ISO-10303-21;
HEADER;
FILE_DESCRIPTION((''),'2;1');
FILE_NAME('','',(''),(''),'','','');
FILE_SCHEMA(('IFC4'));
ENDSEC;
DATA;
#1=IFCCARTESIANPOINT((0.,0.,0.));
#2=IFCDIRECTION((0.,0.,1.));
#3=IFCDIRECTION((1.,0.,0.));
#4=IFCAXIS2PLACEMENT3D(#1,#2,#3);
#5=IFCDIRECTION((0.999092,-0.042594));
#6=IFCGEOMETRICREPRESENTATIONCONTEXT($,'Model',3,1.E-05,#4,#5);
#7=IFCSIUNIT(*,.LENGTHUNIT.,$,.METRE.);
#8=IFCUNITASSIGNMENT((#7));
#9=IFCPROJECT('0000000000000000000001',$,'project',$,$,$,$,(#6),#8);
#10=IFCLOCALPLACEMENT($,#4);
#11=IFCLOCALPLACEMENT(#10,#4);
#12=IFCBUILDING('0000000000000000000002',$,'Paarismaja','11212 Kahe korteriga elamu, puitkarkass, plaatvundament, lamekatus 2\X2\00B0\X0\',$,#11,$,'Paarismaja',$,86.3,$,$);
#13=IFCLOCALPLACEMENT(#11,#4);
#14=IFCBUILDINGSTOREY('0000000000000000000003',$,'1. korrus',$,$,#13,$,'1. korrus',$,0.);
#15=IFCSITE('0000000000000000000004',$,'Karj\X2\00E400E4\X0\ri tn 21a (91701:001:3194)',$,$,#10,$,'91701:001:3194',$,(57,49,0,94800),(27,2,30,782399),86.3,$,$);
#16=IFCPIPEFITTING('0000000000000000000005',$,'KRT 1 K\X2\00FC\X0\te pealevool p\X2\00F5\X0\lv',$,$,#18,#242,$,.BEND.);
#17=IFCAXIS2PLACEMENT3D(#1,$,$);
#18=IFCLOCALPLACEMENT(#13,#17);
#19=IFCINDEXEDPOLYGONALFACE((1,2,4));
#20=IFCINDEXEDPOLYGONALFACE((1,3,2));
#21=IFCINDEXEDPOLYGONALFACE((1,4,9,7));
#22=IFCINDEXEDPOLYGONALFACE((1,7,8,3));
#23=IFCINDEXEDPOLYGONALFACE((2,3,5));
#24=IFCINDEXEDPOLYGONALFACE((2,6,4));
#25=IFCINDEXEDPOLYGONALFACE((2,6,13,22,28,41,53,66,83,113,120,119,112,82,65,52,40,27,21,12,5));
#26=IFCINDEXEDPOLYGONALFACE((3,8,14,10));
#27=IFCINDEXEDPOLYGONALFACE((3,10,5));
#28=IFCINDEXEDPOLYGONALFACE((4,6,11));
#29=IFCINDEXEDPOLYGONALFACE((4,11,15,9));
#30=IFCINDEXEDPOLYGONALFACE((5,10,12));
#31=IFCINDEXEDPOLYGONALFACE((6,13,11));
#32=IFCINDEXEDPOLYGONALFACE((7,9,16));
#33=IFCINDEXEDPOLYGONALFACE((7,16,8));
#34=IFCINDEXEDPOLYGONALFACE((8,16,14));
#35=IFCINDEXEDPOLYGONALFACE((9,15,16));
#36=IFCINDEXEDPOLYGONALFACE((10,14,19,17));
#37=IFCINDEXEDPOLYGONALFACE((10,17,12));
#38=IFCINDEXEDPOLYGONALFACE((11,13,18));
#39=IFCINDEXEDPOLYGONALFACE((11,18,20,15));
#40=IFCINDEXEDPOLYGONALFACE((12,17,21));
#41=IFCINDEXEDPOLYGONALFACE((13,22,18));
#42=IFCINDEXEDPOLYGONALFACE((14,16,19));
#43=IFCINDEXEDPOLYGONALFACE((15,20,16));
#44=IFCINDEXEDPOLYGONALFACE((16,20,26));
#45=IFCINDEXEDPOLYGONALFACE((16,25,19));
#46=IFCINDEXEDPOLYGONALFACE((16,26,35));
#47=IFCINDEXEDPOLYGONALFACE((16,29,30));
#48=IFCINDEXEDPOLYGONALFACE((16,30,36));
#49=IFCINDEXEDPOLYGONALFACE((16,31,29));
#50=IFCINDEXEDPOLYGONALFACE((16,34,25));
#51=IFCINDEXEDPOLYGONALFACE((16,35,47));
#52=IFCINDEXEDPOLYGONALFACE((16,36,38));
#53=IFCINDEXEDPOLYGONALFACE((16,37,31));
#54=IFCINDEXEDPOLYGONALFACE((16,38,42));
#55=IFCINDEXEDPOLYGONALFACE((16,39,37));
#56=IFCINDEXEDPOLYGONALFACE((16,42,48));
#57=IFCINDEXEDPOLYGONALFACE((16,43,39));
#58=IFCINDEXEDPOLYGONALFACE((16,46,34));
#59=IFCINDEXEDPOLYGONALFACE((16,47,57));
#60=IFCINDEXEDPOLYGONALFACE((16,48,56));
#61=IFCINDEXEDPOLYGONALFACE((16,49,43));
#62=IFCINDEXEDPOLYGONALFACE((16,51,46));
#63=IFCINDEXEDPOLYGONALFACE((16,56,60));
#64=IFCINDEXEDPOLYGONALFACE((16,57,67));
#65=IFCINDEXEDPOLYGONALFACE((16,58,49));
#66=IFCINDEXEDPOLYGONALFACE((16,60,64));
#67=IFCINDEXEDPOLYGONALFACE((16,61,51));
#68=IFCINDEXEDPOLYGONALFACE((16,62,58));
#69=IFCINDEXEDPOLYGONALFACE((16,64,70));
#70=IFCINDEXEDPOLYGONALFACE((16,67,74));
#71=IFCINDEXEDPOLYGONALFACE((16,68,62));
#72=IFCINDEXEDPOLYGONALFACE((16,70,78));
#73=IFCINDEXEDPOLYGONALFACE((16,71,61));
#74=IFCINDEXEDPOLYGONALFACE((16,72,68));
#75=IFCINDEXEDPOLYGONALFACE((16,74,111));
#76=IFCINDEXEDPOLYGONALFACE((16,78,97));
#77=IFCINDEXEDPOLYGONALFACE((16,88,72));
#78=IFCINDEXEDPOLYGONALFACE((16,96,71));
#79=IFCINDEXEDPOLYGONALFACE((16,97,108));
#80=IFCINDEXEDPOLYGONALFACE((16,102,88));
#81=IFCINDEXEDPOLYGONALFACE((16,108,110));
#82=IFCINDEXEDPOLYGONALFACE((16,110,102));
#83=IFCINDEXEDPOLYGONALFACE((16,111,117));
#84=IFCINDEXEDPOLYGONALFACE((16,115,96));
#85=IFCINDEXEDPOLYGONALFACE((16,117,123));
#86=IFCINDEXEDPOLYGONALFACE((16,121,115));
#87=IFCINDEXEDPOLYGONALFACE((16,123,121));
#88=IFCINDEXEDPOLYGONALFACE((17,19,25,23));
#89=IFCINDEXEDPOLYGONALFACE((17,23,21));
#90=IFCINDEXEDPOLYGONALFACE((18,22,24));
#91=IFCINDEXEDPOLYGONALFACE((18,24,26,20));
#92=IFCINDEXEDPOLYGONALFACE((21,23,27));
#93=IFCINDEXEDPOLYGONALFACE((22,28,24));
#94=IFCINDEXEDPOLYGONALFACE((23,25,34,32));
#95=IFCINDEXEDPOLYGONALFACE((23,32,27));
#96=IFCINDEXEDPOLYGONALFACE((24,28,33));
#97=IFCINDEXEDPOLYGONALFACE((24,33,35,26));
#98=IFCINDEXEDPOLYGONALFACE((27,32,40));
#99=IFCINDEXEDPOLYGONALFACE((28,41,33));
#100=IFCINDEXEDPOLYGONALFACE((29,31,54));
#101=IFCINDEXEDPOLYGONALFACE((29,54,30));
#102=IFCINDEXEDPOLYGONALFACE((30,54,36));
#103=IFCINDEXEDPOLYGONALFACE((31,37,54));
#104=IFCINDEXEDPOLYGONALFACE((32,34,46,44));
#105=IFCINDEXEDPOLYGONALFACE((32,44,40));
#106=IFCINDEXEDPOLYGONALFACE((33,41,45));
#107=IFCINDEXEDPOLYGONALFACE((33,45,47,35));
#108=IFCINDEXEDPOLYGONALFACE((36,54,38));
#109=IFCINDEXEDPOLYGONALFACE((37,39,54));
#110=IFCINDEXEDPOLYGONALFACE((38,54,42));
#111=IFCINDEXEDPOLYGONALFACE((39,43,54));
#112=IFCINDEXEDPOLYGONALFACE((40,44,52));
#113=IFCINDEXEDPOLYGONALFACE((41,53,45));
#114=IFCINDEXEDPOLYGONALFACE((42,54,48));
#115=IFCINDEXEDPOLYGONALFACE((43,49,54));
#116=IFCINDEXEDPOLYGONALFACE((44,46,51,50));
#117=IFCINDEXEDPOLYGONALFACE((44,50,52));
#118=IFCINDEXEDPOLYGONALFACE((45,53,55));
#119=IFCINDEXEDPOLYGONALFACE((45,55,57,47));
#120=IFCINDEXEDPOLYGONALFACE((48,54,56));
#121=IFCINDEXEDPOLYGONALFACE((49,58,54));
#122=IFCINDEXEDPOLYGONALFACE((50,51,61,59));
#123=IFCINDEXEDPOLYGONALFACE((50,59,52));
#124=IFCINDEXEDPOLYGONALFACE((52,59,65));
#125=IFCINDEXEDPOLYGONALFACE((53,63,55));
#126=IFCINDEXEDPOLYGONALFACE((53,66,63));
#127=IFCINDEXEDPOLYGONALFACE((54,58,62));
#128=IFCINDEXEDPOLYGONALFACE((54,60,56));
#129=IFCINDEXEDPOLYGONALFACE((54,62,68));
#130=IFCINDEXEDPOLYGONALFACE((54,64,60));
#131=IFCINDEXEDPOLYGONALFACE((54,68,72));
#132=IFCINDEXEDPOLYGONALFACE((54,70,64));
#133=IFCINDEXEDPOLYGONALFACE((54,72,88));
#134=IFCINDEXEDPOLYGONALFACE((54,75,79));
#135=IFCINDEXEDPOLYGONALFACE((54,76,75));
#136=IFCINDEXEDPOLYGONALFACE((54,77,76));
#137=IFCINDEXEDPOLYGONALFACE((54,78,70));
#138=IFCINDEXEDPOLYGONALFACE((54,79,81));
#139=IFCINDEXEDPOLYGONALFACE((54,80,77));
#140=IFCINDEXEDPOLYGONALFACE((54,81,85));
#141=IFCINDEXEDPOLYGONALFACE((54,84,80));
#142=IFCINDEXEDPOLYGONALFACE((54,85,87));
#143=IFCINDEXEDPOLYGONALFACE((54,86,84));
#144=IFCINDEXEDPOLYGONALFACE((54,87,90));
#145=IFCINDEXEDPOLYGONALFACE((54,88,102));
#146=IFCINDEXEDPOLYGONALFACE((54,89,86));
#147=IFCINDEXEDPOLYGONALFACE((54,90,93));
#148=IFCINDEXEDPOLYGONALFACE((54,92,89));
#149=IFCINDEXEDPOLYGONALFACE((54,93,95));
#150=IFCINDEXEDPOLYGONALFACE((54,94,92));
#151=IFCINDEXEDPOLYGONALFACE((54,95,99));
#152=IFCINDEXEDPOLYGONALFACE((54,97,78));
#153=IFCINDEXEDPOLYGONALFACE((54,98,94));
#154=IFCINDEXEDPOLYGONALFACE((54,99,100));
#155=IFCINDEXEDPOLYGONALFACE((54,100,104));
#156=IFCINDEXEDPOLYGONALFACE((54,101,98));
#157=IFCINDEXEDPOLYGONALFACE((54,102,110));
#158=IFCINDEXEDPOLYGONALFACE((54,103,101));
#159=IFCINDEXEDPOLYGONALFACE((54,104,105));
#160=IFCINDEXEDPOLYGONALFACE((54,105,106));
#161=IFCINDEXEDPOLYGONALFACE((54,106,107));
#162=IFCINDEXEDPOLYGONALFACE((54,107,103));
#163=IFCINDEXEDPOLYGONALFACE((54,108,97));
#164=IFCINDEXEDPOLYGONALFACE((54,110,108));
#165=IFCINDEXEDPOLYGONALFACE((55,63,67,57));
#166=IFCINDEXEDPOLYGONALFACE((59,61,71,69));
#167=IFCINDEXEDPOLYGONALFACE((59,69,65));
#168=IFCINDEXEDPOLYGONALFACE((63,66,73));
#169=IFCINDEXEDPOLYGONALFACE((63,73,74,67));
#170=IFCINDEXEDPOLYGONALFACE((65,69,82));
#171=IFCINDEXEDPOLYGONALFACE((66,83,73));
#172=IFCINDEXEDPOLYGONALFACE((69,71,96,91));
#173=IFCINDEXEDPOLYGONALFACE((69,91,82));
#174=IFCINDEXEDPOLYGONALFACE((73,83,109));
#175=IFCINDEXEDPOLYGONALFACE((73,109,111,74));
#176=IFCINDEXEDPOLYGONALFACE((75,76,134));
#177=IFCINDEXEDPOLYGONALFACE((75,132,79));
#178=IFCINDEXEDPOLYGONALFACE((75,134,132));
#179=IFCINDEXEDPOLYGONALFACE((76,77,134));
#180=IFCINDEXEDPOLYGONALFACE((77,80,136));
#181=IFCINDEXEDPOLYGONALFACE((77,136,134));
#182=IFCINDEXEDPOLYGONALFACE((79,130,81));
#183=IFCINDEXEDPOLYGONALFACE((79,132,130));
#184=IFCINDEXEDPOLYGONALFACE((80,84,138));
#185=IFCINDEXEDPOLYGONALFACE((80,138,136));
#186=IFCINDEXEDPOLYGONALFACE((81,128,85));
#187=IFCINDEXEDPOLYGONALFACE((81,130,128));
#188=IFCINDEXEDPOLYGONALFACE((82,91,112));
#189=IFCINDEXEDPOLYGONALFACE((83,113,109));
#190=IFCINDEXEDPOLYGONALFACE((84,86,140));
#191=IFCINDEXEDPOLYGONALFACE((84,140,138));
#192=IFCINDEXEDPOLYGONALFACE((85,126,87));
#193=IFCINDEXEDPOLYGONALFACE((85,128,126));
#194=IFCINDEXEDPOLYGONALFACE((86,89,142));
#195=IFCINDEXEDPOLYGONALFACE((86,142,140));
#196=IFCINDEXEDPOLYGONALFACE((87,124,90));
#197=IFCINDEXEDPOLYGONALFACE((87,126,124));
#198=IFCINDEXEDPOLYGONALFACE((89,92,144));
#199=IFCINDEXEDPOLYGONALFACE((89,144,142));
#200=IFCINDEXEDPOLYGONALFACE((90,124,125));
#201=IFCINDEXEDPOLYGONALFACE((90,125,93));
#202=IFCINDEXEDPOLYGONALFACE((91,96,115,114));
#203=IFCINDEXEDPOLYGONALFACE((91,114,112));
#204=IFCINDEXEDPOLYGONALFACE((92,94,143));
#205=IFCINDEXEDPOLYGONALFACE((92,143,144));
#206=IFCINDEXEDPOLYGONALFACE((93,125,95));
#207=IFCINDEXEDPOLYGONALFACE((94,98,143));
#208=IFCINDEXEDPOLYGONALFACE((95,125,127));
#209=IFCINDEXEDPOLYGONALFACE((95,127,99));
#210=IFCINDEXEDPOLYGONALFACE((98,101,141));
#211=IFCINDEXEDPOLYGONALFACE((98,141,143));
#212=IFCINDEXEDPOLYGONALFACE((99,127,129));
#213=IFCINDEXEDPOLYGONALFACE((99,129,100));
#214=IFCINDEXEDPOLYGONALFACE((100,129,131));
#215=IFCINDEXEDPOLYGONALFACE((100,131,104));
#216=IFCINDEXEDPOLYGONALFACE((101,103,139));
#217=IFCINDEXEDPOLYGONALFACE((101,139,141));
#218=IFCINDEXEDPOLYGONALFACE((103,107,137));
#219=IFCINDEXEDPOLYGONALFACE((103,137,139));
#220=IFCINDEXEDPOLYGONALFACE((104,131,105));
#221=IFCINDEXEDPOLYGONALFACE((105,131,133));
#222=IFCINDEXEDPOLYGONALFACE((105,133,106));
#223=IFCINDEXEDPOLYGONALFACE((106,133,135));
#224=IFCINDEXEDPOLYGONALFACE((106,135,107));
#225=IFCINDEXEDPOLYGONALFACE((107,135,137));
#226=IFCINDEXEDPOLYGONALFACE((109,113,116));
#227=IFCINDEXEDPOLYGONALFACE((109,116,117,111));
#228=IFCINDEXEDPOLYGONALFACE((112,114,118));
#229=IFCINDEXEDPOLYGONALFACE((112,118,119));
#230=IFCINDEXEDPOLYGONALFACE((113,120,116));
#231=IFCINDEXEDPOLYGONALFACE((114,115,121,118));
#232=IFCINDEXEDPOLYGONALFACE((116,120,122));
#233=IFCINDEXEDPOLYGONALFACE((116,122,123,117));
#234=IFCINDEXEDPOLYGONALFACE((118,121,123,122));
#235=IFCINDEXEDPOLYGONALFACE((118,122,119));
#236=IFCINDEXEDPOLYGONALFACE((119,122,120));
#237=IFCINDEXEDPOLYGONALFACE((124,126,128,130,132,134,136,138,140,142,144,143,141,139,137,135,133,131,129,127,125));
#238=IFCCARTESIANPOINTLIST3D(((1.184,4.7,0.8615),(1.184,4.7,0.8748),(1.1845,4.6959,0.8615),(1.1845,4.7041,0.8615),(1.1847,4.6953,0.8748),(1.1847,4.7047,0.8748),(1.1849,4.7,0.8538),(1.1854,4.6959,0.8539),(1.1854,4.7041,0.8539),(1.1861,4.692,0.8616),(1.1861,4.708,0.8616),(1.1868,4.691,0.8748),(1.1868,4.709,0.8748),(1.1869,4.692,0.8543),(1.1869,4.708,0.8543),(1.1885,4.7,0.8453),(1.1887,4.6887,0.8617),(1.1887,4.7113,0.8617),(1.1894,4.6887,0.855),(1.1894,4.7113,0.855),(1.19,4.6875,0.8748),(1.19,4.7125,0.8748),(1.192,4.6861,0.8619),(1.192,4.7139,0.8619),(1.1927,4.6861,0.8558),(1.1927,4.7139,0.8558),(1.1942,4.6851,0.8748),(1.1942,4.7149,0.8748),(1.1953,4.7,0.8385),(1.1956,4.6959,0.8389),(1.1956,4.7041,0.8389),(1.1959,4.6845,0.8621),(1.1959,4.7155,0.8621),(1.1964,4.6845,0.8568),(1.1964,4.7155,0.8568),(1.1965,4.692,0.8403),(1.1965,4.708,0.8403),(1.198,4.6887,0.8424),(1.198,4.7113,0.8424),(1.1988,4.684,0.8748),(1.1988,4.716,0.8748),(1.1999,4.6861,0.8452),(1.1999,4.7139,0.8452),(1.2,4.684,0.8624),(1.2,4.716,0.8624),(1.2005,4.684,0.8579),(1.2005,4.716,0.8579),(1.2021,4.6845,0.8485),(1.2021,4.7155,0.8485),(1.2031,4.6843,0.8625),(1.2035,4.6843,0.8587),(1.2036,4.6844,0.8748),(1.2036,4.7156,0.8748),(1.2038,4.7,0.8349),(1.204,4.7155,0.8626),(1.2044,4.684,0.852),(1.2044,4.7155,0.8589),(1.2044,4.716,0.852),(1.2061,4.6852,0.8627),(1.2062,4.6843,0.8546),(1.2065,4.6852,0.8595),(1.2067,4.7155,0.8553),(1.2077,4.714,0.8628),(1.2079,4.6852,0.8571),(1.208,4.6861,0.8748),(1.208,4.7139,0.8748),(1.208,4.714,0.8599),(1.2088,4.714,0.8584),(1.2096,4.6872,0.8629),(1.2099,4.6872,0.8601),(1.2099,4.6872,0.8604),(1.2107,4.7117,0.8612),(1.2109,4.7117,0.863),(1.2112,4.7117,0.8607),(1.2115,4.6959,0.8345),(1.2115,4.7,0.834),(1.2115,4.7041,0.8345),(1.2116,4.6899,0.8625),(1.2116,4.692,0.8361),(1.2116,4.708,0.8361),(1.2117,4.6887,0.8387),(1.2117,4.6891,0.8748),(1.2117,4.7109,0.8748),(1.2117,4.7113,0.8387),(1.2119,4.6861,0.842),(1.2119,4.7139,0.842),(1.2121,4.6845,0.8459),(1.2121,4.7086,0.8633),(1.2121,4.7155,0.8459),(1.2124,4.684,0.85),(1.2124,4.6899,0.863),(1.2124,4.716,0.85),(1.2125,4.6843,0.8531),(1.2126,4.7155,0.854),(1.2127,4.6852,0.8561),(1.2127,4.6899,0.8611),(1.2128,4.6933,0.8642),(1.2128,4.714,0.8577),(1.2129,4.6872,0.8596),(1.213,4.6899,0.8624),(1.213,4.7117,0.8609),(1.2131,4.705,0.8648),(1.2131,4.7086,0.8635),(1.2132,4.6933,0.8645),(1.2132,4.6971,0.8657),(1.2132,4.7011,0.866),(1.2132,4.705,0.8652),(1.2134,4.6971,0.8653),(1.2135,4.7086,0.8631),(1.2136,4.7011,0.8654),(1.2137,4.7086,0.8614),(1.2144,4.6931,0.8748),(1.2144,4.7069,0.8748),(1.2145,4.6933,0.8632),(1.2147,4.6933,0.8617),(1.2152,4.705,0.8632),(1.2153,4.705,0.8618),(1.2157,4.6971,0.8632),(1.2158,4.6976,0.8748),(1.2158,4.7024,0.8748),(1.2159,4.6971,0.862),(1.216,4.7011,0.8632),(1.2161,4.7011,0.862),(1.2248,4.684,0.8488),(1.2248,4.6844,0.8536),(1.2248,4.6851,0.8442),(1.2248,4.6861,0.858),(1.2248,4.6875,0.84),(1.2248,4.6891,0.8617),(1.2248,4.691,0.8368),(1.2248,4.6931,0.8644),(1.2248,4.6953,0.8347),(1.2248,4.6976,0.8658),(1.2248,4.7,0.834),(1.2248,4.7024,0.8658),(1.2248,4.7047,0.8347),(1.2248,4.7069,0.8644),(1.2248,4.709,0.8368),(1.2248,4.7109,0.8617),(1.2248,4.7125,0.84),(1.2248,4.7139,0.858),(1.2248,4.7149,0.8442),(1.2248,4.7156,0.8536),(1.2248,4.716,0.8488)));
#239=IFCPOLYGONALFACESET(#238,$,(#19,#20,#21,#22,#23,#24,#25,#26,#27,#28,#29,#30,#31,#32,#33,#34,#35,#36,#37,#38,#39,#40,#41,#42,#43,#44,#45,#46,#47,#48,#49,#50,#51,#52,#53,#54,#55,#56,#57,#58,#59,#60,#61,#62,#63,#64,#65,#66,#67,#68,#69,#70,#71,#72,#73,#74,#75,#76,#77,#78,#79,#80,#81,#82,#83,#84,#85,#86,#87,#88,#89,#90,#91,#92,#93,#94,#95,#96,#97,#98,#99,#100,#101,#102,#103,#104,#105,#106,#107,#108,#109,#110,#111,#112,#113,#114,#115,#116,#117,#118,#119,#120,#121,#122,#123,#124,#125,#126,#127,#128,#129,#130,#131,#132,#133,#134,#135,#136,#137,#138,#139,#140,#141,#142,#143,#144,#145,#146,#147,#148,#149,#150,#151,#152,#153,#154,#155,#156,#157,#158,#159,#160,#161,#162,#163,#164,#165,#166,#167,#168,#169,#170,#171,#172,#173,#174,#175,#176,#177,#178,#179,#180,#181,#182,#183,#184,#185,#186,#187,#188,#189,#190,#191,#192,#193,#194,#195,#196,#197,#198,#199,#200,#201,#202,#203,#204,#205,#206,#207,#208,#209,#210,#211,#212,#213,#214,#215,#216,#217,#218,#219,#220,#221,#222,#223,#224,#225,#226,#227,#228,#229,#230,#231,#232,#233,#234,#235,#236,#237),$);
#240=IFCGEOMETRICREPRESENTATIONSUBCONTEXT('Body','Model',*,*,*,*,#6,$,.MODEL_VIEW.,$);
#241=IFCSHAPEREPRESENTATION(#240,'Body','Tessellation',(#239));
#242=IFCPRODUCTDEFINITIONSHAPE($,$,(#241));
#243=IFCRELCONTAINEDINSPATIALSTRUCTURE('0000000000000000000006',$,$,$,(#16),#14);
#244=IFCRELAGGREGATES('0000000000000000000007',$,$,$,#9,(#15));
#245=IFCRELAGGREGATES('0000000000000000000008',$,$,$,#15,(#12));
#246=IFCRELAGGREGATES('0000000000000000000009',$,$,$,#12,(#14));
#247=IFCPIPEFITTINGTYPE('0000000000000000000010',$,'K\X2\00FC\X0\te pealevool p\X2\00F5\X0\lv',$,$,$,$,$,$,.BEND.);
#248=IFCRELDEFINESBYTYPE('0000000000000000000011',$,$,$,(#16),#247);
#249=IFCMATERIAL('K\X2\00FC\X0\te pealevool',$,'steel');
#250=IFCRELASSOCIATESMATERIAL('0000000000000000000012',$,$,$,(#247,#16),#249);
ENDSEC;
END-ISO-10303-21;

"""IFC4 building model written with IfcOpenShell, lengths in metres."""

from ifc_helpers import new_model, entity, si_unit, direction, frame, origin_with_axes, place, context, subcontext, project, spatial, material, type_object, element, save


model = new_model("IFC4")

# Units and contexts
model_context = context("Model", 3, precision=1e-05, world=origin_with_axes(), true_north=direction((0.999092, -0.042594)))
body_context = subcontext(model_context, "Body", "Model", "MODEL_VIEW")
ifc_project = project(units=[si_unit("LENGTHUNIT", "METRE")], contexts=[model_context])

# Site, building, storey
site_placement = place(None, origin_with_axes())
site = spatial("IfcSite", under=ifc_project, at=site_placement, Name="Karjääri tn 21a (91701:001:3194)", LongName="91701:001:3194", RefLatitude=(57, 49, 0, 94800), RefLongitude=(27, 2, 30, 782399), RefElevation=86.3)
building_placement = place(site_placement, origin_with_axes())
building = spatial("IfcBuilding", under=site, at=building_placement, Name="Paarismaja", Description="11212 Kahe korteriga elamu, puitkarkass, plaatvundament, lamekatus 2°", LongName="Paarismaja", ElevationOfRefHeight=86.3)
storey_placement = place(building_placement, origin_with_axes())
storey = spatial("IfcBuildingStorey", under=building, at=storey_placement, Name="1. korrus", LongName="1. korrus", Elevation=0.0)

# Pipe fitting
ifc_material_1 = material(Name="Küte pealevool", Category="steel")
pipe_fitting_type_1 = type_object("IfcPipeFittingType", Name="Küte pealevool põlv", PredefinedType="BEND", material=ifc_material_1)
pipe_fitting_1_placement = place(storey_placement, frame((1.2, 4.7, 0.85), z_axis=(0.0, 0.0, 1.0), x_axis=(1.0, 0.0, 0.0)))
element("IfcPipeFitting", 1, at=pipe_fitting_1_placement, inside=storey, type_object=pipe_fitting_type_1, material=ifc_material_1, Name="KRT 1 Küte pealevool põlv", PredefinedType="BEND", context=body_context, shape_type="AdvancedSweptSolid", body=[
    entity("IfcSweptDiskSolid", entity("IfcIndexedPolyCurve", entity("IfcCartesianPointList3D", [[0.0, 0.0, 0.0248], [0.0, 0.0, 0.0124], [0.0005, 0.0, 0.0079], [0.002, 0.0, 0.0044], [0.0044, 0.0, 0.002], [0.0079, 0.0, 0.0005], [0.0124, 0.0, 0.0], [0.0248, 0.0, 0.0]]), None, False), 0.016),
])

save(model, "model.ifc")
